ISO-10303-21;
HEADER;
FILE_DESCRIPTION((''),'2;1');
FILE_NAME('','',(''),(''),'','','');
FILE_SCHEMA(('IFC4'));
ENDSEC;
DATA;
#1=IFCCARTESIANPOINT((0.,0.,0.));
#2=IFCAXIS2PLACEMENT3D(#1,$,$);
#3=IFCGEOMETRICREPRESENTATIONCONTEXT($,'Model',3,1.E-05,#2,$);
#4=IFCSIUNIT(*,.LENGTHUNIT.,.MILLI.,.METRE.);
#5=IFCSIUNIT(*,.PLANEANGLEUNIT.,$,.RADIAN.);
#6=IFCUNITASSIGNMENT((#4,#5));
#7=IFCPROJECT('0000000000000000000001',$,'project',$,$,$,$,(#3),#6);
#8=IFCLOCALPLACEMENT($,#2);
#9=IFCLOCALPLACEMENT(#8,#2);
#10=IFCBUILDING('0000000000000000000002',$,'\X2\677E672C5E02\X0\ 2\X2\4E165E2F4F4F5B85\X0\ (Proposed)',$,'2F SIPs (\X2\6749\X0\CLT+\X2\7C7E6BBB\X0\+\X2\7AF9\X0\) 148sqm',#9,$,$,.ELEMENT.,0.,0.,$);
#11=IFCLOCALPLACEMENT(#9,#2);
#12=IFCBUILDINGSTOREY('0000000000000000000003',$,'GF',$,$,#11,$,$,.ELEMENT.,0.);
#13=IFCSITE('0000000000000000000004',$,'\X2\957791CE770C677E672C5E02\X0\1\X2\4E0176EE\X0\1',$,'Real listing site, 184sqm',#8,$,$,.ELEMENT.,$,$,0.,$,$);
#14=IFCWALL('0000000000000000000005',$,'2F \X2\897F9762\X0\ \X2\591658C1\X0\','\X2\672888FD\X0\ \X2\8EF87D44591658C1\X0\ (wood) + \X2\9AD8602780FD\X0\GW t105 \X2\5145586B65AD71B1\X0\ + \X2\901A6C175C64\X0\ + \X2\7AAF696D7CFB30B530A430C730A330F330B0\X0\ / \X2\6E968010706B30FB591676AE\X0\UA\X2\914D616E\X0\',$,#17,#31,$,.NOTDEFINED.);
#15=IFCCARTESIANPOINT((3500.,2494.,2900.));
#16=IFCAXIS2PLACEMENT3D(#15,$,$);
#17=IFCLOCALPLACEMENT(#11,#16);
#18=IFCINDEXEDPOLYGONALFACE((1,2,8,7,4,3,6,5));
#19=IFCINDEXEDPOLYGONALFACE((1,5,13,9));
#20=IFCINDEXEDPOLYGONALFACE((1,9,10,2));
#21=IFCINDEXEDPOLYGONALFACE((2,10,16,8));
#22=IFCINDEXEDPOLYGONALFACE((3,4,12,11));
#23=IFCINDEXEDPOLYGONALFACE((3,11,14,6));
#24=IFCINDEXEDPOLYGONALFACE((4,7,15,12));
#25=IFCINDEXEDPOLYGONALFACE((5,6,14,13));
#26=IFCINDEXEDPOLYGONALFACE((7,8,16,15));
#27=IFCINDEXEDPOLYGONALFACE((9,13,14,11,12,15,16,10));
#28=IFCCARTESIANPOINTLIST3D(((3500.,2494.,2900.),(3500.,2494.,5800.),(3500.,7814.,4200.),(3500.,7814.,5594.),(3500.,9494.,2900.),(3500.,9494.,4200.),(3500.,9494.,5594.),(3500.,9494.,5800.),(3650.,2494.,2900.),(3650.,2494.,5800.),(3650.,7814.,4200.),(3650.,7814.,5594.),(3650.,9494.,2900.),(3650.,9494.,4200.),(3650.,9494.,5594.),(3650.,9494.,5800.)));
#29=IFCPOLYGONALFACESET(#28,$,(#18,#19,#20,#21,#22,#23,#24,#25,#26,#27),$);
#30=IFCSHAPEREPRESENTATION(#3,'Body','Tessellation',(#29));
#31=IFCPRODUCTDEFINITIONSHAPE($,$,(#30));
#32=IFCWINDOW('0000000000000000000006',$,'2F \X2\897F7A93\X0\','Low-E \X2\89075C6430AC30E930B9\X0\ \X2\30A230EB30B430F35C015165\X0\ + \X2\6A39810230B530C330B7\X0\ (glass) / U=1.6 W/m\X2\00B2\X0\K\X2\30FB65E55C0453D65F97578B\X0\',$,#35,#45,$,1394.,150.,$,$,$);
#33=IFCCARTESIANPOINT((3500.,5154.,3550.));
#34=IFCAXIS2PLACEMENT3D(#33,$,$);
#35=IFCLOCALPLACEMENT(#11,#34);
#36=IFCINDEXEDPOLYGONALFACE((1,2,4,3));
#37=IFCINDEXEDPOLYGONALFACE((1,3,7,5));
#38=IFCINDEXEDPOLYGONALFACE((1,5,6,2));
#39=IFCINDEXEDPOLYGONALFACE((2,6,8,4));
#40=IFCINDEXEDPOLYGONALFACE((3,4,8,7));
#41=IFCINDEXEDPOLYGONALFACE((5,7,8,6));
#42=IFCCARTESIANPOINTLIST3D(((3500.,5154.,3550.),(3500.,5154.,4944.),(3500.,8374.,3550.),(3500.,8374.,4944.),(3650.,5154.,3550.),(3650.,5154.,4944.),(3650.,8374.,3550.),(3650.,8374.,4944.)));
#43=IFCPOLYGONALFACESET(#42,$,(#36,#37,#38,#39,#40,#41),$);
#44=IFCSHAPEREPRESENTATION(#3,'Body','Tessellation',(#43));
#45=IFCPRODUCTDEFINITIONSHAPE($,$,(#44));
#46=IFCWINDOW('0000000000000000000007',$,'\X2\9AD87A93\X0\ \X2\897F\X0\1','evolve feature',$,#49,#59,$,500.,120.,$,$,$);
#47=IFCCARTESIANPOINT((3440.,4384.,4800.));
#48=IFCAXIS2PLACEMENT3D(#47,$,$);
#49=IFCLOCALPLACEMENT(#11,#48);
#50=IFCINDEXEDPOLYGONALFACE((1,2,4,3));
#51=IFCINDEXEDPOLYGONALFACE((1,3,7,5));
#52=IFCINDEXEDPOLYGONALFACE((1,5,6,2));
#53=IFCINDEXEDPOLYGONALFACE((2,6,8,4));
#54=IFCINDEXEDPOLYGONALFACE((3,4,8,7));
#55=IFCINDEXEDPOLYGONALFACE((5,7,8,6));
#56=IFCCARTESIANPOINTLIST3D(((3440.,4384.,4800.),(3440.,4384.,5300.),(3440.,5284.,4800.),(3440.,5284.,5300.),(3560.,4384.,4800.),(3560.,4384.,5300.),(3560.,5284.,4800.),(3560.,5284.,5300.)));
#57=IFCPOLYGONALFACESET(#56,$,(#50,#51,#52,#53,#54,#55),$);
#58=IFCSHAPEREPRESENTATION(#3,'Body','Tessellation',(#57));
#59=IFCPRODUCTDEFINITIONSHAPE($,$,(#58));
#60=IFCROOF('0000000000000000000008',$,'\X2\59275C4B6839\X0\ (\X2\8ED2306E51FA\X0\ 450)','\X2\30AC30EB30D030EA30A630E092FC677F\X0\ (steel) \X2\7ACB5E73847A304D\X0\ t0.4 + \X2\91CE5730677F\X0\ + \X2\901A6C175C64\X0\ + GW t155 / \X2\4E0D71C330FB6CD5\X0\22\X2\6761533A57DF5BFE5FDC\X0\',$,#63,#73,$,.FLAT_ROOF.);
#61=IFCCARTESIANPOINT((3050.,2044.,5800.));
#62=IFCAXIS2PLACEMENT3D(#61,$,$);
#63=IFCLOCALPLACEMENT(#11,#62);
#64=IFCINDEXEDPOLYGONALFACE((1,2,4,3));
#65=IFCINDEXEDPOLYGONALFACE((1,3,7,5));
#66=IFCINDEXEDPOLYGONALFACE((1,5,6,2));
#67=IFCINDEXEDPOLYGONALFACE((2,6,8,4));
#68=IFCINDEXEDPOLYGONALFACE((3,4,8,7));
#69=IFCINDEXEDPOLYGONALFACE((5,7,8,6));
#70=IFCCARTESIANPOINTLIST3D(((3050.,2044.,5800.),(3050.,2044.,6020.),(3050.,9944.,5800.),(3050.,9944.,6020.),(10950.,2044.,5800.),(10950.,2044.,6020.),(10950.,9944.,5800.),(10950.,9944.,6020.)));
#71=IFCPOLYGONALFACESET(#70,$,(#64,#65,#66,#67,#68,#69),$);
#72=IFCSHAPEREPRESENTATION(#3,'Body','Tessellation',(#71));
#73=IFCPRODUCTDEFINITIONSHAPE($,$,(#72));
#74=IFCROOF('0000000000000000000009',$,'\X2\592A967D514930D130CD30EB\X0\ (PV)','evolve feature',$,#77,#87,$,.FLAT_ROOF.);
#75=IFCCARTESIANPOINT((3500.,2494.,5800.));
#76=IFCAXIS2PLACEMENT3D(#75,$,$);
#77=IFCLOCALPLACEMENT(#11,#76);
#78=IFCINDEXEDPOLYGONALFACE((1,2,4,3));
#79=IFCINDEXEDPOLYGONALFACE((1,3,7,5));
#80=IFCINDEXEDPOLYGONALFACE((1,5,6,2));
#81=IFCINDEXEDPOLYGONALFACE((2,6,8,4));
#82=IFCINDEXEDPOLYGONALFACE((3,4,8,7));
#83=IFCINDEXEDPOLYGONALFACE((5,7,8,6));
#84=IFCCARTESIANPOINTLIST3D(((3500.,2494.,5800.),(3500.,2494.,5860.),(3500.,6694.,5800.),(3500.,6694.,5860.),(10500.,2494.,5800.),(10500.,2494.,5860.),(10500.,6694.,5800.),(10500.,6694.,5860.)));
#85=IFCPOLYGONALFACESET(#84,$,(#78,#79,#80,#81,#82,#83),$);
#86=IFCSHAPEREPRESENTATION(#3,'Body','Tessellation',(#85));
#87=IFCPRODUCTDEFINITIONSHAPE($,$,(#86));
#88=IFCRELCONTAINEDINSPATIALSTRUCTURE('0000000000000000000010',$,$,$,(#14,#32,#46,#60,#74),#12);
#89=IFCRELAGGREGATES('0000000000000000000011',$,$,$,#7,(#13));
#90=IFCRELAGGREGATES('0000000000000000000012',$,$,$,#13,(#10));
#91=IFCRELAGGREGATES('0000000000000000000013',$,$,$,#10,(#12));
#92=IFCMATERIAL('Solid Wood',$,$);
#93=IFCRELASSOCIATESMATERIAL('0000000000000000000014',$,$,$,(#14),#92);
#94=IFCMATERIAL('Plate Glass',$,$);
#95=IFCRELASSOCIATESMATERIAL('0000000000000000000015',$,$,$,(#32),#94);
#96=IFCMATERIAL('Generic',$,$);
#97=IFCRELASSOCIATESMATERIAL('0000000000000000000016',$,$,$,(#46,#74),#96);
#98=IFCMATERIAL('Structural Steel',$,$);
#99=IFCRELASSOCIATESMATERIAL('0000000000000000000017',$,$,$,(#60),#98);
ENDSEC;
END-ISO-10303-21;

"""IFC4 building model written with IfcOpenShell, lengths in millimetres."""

from ifc_helpers import new_model, si_unit, frame, frame_2d, origin, place, context, project, spatial, rectangle, extrude, material, element, fill, save


model = new_model("IFC4")

# Units and contexts
model_context = context("Model", 3, precision=1e-05, world=origin())
ifc_project = project(units=[si_unit("LENGTHUNIT", "METRE", prefix="MILLI"), si_unit("PLANEANGLEUNIT", "RADIAN")], contexts=[model_context])

# Site, building, storey
site_placement = place(None, origin())
site = spatial("IfcSite", under=ifc_project, at=site_placement, Name="長野県松本市1丁目1", ObjectType="Real listing site, 184sqm", CompositionType="ELEMENT", RefElevation=0.0)
building_placement = place(site_placement, origin())
building = spatial("IfcBuilding", under=site, at=building_placement, Name="松本市 2世帯住宅 (Proposed)", ObjectType="2F SIPs (杉CLT+籾殻+竹) 148sqm", CompositionType="ELEMENT", ElevationOfRefHeight=0.0, ElevationOfTerrain=0.0)
storey_placement = place(building_placement, origin())
storey = spatial("IfcBuildingStorey", under=building, at=storey_placement, Name="GF", CompositionType="ELEMENT", Elevation=0.0)

# Shared definitions
ifc_material_1 = material(Name="Solid Wood")
ifc_material_2 = material(Name="Generic")

# Shared definitions
ifc_material_3 = material(Name="Plate Glass")

# Wall, openings, windows
wall_1_placement = place(storey_placement, frame((3500.0, 2494.0, 2900.0)))
wall_1 = element("IfcWall", 1, at=wall_1_placement, inside=storey, material=ifc_material_1, Name="2F 西面 外壁", Description="木製 軸組外壁 (wood) + 高性能GW t105 充填断熱 + 通気層 + 窯業系サイディング / 準耐火・外皮UA配慮", PredefinedType="NOTDEFINED", context=model_context, shape_type="SweptSolid", body=[
    extrude(rectangle(XDim=150.0, YDim=7000.0, at=frame_2d((75.0, 3500.0))), frame((3500.0, 2494.0, 2900.0)), (0.0, 0.0, 1.0), 2900.0),
])
opening_1_placement = place(storey_placement, frame((3500.0, 5154.0, 3550.0)))
opening_1 = element("IfcOpeningElement", 2, at=opening_1_placement, cuts=wall_1, PredefinedType="NOTDEFINED", context=model_context, shape_type="SweptSolid", body=[
    extrude(rectangle(XDim=150.0, YDim=3220.0, at=frame_2d((75.0, 1610.0))), frame((3500.0, 5154.0, 3550.0)), (0.0, 0.0, 1.0), 1394.0),
])
opening_2_placement = place(storey_placement, frame((3440.0, 4384.0, 4800.0)))
opening_2 = element("IfcOpeningElement", 3, at=opening_2_placement, cuts=wall_1, PredefinedType="NOTDEFINED", context=model_context, shape_type="SweptSolid", body=[
    extrude(rectangle(XDim=120.0, YDim=900.0, at=frame_2d((60.0, 450.0))), frame((3440.0, 4384.0, 4800.0)), (0.0, 0.0, 1.0), 500.0),
])
window_1_placement = place(storey_placement, frame((3500.0, 5154.0, 3550.0)))
window_1 = element("IfcWindow", 4, at=window_1_placement, inside=storey, material=ifc_material_3, Name="2F 西窓", Description="Low-E 複層ガラス アルゴン封入 + 樹脂サッシ (glass) / U=1.6 W/m²K・日射取得型", OverallHeight=1394.0, OverallWidth=150.0, context=model_context, shape_type="SweptSolid", body=[
    extrude(rectangle(XDim=150.0, YDim=3220.0, at=frame_2d((75.0, 1610.0))), frame((3500.0, 5154.0, 3550.0)), (0.0, 0.0, 1.0), 1394.0),
])
fill(opening_1, window_1)
window_2_placement = place(storey_placement, frame((3440.0, 4384.0, 4800.0)))
window_2 = element("IfcWindow", 5, at=window_2_placement, inside=storey, material=ifc_material_2, Name="高窓 西1", Description="evolve feature", OverallHeight=500.0, OverallWidth=120.0, context=model_context, shape_type="SweptSolid", body=[
    extrude(rectangle(XDim=120.0, YDim=900.0, at=frame_2d((60.0, 450.0))), frame((3440.0, 4384.0, 4800.0)), (0.0, 0.0, 1.0), 500.0),
])
fill(opening_2, window_2)

# Roofs
ifc_material_4 = material(Name="Structural Steel")
roof_1_placement = place(storey_placement, frame((3050.0, 2044.0, 5800.0)))
element("IfcRoof", 6, at=roof_1_placement, inside=storey, material=ifc_material_4, Name="大屋根 (軒の出 450)", Description="ガルバリウム鋼板 (steel) 立平葺き t0.4 + 野地板 + 通気層 + GW t155 / 不燃・法22条区域対応", PredefinedType="FLAT_ROOF", context=model_context, shape_type="SweptSolid", body=[
    extrude(rectangle(XDim=7900.0, YDim=7900.0, at=frame_2d((3950.0, 3950.0))), frame((3050.0, 2044.0, 5800.0)), (0.0, 0.0, 1.0), 220.0),
])
roof_2_placement = place(storey_placement, frame((3500.0, 2494.0, 5800.0)))
element("IfcRoof", 7, at=roof_2_placement, inside=storey, material=ifc_material_2, Name="太陽光パネル (PV)", Description="evolve feature", PredefinedType="FLAT_ROOF", context=model_context, shape_type="SweptSolid", body=[
    extrude(rectangle(XDim=7000.0, YDim=4200.0, at=frame_2d((3500.0, 2100.0))), frame((3500.0, 2494.0, 5800.0)), (0.0, 0.0, 1.0), 60.0),
])

save(model, "model.ifc")
